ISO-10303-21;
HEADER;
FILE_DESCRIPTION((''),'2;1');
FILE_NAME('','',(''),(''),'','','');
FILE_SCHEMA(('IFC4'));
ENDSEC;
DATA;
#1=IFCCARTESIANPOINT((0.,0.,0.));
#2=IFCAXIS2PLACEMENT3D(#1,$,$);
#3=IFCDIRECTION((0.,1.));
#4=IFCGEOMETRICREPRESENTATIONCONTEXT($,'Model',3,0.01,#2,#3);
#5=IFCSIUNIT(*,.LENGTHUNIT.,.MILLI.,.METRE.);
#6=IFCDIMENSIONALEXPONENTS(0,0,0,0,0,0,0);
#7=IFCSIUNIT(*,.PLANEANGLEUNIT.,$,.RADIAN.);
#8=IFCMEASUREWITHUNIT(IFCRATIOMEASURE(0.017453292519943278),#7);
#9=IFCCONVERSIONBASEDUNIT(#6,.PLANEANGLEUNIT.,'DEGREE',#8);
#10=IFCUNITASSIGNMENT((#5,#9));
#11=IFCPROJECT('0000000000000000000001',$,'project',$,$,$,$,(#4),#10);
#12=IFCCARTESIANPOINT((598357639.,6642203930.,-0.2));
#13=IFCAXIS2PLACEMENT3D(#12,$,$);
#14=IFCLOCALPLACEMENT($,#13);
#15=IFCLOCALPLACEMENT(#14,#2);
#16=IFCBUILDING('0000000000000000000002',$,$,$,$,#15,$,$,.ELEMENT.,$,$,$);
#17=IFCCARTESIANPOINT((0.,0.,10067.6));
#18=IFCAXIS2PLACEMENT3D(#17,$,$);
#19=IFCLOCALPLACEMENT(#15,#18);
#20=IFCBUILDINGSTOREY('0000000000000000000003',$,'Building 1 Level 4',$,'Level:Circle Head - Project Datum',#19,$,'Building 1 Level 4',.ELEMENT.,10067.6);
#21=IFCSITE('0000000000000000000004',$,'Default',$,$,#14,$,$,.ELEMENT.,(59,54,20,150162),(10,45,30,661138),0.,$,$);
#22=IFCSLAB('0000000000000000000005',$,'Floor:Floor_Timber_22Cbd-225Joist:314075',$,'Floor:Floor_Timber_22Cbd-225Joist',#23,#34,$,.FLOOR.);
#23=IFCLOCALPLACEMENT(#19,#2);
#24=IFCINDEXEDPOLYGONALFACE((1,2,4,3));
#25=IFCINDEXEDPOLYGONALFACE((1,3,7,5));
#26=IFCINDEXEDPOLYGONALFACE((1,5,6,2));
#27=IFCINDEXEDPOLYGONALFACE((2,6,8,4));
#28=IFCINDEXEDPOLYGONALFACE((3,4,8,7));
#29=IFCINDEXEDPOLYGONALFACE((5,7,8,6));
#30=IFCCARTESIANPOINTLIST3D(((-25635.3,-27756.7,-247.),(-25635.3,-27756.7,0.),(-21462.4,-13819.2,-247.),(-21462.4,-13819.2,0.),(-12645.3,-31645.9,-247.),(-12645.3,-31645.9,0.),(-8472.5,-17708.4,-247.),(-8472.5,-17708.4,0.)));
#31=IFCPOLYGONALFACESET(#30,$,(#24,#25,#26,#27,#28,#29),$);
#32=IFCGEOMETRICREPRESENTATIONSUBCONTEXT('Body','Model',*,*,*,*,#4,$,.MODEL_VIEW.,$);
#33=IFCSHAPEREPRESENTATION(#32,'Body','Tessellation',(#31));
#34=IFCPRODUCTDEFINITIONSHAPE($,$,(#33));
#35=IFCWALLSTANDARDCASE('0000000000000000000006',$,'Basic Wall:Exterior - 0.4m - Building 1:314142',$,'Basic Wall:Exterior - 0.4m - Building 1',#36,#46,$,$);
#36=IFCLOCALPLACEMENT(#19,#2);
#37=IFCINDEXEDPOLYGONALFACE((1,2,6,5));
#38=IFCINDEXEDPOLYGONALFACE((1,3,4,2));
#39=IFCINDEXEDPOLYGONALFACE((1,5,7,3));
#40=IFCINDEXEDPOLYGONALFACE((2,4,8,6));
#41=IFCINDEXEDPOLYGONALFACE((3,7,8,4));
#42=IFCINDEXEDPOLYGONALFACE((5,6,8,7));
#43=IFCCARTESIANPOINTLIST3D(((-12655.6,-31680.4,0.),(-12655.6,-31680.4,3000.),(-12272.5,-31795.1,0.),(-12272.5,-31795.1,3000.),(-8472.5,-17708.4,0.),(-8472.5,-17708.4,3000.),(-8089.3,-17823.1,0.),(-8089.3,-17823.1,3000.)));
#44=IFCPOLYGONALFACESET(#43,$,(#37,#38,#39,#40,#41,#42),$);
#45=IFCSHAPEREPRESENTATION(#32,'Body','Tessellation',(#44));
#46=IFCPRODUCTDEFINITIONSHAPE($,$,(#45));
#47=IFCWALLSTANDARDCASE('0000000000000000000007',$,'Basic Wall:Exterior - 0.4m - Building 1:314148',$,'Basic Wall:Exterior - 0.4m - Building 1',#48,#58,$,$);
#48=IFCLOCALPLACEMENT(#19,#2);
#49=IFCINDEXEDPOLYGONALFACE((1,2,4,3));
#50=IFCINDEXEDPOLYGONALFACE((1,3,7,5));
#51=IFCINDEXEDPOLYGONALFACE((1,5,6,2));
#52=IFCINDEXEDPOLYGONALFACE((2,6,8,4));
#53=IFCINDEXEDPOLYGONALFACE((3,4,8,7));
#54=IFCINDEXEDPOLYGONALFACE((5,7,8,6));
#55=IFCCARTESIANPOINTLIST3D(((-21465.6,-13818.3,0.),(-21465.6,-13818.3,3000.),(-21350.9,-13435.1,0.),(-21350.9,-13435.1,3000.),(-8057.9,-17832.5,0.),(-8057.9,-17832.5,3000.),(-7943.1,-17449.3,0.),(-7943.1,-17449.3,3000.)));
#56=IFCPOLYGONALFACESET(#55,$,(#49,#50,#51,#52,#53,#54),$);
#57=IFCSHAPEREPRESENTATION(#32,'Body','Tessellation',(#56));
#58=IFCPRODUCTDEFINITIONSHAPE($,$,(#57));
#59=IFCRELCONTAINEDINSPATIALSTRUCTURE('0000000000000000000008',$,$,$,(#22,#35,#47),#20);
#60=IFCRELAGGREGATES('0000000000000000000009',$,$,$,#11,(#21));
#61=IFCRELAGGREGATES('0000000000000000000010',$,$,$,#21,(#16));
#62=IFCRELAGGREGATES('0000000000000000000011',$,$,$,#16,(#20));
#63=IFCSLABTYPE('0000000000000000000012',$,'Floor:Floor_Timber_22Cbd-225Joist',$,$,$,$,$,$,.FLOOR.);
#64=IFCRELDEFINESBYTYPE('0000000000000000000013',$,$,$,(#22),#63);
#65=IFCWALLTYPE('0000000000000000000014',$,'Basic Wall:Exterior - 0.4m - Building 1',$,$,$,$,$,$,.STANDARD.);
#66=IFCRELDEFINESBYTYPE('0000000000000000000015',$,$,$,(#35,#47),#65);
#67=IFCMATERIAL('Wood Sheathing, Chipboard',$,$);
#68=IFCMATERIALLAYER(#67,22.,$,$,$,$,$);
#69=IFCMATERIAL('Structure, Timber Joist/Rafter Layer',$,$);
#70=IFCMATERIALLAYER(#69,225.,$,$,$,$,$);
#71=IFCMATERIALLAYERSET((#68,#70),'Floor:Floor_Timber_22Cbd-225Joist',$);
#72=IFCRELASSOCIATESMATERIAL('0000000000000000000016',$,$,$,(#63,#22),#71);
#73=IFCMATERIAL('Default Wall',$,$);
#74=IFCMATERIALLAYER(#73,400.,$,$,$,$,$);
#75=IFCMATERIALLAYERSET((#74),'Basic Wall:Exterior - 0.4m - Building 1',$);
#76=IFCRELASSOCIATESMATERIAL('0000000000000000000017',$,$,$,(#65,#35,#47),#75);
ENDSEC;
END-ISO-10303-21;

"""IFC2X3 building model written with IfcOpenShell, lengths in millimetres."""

from ifc_helpers import new_model, entity, si_unit, converted_unit, direction, frame, frame_2d, origin, place, context, subcontext, project, spatial, rectangle, extrude, material, layer, layer_set, layer_usage, type_object, element, save


model = new_model("IFC2X3")

# Units and contexts
model_context = context("Model", 3, precision=0.01, world=origin(), true_north=direction((0.0, 1.0)))
body_context = subcontext(model_context, "Body", "Model", "MODEL_VIEW")
ifc_project = project(units=[si_unit("LENGTHUNIT", "METRE", prefix="MILLI"), converted_unit("PLANEANGLEUNIT", "DEGREE", entity("IfcRatioMeasure", 0.017453292519943278), si_unit("PLANEANGLEUNIT", "RADIAN"), dimensions=[0, 0, 0, 0, 0, 0, 0])], contexts=[model_context])

# Site, building, storey
site_placement = place(None, frame((598357639.0, 6642203930.0, -0.2)))
site = spatial("IfcSite", under=ifc_project, at=site_placement, Name="Default", CompositionType="ELEMENT", RefLatitude=(59, 54, 20, 150162), RefLongitude=(10, 45, 30, 661138), RefElevation=0.0)
building_placement = place(site_placement, origin())
building = spatial("IfcBuilding", under=site, at=building_placement, CompositionType="ELEMENT")
storey_placement = place(building_placement, frame((0.0, 0.0, 10067.6)))
storey = spatial("IfcBuildingStorey", under=building, at=storey_placement, Name="Building 1 Level 4", ObjectType="Level:Circle Head - Project Datum", LongName="Building 1 Level 4", CompositionType="ELEMENT", Elevation=10067.6)

# Slab
ifc_material_1 = material(Name="Wood Sheathing, Chipboard")
ifc_layer_1 = layer(ifc_material_1, 22.0)
ifc_material_2 = material(Name="Structure, Timber Joist/Rafter Layer")
ifc_layer_2 = layer(ifc_material_2, 225.0)
ifc_layer_set_1 = layer_set([ifc_layer_1, ifc_layer_2], Name="Floor:Floor_Timber_22Cbd-225Joist")
ifc_layer_usage_1 = layer_usage(ifc_layer_set_1, "AXIS3", "POSITIVE", 0.0)
slab_type = type_object("IfcSlabType", Name="Floor:Floor_Timber_22Cbd-225Joist", PredefinedType="FLOOR", material=ifc_layer_set_1)
slab_placement = place(storey_placement, origin())
element("IfcSlab", 1, at=slab_placement, inside=storey, type_object=slab_type, material=ifc_layer_usage_1, Name="Floor:Floor_Timber_22Cbd-225Joist:314075", ObjectType="Floor:Floor_Timber_22Cbd-225Joist", PredefinedType="FLOOR", context=body_context, shape_type="SweptSolid", body=[
    extrude(rectangle(XDim=14548.8, YDim=13559.7, at=frame_2d((0.0, 0.0), x_axis=(1.0, 0.0))), frame((-17053.9, -22732.6, 0.0), z_axis=(0.0, 0.0, -1.0), x_axis=(-0.286817, -0.957985, 0.0)), (0.0, 0.0, 1.0), 247.0),
])

# Walls
ifc_material_3 = material(Name="Default Wall")
ifc_layer_3 = layer(ifc_material_3, 400.0)
ifc_layer_set_2 = layer_set([ifc_layer_3], Name="Basic Wall:Exterior - 0.4m - Building 1")
ifc_layer_usage_2 = layer_usage(ifc_layer_set_2, "AXIS2", "POSITIVE", -200.0)
wall_type = type_object("IfcWallType", Name="Basic Wall:Exterior - 0.4m - Building 1", PredefinedType="STANDARD", material=ifc_layer_set_2)
wall_1_placement = place(storey_placement, frame((-12464.1, -31737.8, 0.0), z_axis=(0.0, 0.0, 1.0), x_axis=(0.286817, 0.957985, 0.0)))
element("IfcWallStandardCase", 2, at=wall_1_placement, inside=storey, type_object=wall_type, material=ifc_layer_usage_2, Name="Basic Wall:Exterior - 0.4m - Building 1:314142", ObjectType="Basic Wall:Exterior - 0.4m - Building 1", context=body_context, shape_type="SweptSolid", body=[
    extrude(rectangle(XDim=14584.8, YDim=400.0, at=frame_2d((7292.4, 0.0), x_axis=(-1.0, 0.0))), origin(), (0.0, 0.0, 1.0), 3000.0),
])
wall_2_placement = place(storey_placement, frame((-8000.5, -17640.9, 0.0), z_axis=(0.0, 0.0, 1.0), x_axis=(-0.957985, 0.286817, 0.0)))
element("IfcWallStandardCase", 3, at=wall_2_placement, inside=storey, type_object=wall_type, material=ifc_layer_usage_2, Name="Basic Wall:Exterior - 0.4m - Building 1:314148", ObjectType="Basic Wall:Exterior - 0.4m - Building 1", context=body_context, shape_type="SweptSolid", body=[
    extrude(rectangle(XDim=13995.7, YDim=400.0, at=frame_2d((6997.9, 0.0), x_axis=(-1.0, 0.0))), origin(), (0.0, 0.0, 1.0), 3000.0),
])

save(model, "model.ifc")
